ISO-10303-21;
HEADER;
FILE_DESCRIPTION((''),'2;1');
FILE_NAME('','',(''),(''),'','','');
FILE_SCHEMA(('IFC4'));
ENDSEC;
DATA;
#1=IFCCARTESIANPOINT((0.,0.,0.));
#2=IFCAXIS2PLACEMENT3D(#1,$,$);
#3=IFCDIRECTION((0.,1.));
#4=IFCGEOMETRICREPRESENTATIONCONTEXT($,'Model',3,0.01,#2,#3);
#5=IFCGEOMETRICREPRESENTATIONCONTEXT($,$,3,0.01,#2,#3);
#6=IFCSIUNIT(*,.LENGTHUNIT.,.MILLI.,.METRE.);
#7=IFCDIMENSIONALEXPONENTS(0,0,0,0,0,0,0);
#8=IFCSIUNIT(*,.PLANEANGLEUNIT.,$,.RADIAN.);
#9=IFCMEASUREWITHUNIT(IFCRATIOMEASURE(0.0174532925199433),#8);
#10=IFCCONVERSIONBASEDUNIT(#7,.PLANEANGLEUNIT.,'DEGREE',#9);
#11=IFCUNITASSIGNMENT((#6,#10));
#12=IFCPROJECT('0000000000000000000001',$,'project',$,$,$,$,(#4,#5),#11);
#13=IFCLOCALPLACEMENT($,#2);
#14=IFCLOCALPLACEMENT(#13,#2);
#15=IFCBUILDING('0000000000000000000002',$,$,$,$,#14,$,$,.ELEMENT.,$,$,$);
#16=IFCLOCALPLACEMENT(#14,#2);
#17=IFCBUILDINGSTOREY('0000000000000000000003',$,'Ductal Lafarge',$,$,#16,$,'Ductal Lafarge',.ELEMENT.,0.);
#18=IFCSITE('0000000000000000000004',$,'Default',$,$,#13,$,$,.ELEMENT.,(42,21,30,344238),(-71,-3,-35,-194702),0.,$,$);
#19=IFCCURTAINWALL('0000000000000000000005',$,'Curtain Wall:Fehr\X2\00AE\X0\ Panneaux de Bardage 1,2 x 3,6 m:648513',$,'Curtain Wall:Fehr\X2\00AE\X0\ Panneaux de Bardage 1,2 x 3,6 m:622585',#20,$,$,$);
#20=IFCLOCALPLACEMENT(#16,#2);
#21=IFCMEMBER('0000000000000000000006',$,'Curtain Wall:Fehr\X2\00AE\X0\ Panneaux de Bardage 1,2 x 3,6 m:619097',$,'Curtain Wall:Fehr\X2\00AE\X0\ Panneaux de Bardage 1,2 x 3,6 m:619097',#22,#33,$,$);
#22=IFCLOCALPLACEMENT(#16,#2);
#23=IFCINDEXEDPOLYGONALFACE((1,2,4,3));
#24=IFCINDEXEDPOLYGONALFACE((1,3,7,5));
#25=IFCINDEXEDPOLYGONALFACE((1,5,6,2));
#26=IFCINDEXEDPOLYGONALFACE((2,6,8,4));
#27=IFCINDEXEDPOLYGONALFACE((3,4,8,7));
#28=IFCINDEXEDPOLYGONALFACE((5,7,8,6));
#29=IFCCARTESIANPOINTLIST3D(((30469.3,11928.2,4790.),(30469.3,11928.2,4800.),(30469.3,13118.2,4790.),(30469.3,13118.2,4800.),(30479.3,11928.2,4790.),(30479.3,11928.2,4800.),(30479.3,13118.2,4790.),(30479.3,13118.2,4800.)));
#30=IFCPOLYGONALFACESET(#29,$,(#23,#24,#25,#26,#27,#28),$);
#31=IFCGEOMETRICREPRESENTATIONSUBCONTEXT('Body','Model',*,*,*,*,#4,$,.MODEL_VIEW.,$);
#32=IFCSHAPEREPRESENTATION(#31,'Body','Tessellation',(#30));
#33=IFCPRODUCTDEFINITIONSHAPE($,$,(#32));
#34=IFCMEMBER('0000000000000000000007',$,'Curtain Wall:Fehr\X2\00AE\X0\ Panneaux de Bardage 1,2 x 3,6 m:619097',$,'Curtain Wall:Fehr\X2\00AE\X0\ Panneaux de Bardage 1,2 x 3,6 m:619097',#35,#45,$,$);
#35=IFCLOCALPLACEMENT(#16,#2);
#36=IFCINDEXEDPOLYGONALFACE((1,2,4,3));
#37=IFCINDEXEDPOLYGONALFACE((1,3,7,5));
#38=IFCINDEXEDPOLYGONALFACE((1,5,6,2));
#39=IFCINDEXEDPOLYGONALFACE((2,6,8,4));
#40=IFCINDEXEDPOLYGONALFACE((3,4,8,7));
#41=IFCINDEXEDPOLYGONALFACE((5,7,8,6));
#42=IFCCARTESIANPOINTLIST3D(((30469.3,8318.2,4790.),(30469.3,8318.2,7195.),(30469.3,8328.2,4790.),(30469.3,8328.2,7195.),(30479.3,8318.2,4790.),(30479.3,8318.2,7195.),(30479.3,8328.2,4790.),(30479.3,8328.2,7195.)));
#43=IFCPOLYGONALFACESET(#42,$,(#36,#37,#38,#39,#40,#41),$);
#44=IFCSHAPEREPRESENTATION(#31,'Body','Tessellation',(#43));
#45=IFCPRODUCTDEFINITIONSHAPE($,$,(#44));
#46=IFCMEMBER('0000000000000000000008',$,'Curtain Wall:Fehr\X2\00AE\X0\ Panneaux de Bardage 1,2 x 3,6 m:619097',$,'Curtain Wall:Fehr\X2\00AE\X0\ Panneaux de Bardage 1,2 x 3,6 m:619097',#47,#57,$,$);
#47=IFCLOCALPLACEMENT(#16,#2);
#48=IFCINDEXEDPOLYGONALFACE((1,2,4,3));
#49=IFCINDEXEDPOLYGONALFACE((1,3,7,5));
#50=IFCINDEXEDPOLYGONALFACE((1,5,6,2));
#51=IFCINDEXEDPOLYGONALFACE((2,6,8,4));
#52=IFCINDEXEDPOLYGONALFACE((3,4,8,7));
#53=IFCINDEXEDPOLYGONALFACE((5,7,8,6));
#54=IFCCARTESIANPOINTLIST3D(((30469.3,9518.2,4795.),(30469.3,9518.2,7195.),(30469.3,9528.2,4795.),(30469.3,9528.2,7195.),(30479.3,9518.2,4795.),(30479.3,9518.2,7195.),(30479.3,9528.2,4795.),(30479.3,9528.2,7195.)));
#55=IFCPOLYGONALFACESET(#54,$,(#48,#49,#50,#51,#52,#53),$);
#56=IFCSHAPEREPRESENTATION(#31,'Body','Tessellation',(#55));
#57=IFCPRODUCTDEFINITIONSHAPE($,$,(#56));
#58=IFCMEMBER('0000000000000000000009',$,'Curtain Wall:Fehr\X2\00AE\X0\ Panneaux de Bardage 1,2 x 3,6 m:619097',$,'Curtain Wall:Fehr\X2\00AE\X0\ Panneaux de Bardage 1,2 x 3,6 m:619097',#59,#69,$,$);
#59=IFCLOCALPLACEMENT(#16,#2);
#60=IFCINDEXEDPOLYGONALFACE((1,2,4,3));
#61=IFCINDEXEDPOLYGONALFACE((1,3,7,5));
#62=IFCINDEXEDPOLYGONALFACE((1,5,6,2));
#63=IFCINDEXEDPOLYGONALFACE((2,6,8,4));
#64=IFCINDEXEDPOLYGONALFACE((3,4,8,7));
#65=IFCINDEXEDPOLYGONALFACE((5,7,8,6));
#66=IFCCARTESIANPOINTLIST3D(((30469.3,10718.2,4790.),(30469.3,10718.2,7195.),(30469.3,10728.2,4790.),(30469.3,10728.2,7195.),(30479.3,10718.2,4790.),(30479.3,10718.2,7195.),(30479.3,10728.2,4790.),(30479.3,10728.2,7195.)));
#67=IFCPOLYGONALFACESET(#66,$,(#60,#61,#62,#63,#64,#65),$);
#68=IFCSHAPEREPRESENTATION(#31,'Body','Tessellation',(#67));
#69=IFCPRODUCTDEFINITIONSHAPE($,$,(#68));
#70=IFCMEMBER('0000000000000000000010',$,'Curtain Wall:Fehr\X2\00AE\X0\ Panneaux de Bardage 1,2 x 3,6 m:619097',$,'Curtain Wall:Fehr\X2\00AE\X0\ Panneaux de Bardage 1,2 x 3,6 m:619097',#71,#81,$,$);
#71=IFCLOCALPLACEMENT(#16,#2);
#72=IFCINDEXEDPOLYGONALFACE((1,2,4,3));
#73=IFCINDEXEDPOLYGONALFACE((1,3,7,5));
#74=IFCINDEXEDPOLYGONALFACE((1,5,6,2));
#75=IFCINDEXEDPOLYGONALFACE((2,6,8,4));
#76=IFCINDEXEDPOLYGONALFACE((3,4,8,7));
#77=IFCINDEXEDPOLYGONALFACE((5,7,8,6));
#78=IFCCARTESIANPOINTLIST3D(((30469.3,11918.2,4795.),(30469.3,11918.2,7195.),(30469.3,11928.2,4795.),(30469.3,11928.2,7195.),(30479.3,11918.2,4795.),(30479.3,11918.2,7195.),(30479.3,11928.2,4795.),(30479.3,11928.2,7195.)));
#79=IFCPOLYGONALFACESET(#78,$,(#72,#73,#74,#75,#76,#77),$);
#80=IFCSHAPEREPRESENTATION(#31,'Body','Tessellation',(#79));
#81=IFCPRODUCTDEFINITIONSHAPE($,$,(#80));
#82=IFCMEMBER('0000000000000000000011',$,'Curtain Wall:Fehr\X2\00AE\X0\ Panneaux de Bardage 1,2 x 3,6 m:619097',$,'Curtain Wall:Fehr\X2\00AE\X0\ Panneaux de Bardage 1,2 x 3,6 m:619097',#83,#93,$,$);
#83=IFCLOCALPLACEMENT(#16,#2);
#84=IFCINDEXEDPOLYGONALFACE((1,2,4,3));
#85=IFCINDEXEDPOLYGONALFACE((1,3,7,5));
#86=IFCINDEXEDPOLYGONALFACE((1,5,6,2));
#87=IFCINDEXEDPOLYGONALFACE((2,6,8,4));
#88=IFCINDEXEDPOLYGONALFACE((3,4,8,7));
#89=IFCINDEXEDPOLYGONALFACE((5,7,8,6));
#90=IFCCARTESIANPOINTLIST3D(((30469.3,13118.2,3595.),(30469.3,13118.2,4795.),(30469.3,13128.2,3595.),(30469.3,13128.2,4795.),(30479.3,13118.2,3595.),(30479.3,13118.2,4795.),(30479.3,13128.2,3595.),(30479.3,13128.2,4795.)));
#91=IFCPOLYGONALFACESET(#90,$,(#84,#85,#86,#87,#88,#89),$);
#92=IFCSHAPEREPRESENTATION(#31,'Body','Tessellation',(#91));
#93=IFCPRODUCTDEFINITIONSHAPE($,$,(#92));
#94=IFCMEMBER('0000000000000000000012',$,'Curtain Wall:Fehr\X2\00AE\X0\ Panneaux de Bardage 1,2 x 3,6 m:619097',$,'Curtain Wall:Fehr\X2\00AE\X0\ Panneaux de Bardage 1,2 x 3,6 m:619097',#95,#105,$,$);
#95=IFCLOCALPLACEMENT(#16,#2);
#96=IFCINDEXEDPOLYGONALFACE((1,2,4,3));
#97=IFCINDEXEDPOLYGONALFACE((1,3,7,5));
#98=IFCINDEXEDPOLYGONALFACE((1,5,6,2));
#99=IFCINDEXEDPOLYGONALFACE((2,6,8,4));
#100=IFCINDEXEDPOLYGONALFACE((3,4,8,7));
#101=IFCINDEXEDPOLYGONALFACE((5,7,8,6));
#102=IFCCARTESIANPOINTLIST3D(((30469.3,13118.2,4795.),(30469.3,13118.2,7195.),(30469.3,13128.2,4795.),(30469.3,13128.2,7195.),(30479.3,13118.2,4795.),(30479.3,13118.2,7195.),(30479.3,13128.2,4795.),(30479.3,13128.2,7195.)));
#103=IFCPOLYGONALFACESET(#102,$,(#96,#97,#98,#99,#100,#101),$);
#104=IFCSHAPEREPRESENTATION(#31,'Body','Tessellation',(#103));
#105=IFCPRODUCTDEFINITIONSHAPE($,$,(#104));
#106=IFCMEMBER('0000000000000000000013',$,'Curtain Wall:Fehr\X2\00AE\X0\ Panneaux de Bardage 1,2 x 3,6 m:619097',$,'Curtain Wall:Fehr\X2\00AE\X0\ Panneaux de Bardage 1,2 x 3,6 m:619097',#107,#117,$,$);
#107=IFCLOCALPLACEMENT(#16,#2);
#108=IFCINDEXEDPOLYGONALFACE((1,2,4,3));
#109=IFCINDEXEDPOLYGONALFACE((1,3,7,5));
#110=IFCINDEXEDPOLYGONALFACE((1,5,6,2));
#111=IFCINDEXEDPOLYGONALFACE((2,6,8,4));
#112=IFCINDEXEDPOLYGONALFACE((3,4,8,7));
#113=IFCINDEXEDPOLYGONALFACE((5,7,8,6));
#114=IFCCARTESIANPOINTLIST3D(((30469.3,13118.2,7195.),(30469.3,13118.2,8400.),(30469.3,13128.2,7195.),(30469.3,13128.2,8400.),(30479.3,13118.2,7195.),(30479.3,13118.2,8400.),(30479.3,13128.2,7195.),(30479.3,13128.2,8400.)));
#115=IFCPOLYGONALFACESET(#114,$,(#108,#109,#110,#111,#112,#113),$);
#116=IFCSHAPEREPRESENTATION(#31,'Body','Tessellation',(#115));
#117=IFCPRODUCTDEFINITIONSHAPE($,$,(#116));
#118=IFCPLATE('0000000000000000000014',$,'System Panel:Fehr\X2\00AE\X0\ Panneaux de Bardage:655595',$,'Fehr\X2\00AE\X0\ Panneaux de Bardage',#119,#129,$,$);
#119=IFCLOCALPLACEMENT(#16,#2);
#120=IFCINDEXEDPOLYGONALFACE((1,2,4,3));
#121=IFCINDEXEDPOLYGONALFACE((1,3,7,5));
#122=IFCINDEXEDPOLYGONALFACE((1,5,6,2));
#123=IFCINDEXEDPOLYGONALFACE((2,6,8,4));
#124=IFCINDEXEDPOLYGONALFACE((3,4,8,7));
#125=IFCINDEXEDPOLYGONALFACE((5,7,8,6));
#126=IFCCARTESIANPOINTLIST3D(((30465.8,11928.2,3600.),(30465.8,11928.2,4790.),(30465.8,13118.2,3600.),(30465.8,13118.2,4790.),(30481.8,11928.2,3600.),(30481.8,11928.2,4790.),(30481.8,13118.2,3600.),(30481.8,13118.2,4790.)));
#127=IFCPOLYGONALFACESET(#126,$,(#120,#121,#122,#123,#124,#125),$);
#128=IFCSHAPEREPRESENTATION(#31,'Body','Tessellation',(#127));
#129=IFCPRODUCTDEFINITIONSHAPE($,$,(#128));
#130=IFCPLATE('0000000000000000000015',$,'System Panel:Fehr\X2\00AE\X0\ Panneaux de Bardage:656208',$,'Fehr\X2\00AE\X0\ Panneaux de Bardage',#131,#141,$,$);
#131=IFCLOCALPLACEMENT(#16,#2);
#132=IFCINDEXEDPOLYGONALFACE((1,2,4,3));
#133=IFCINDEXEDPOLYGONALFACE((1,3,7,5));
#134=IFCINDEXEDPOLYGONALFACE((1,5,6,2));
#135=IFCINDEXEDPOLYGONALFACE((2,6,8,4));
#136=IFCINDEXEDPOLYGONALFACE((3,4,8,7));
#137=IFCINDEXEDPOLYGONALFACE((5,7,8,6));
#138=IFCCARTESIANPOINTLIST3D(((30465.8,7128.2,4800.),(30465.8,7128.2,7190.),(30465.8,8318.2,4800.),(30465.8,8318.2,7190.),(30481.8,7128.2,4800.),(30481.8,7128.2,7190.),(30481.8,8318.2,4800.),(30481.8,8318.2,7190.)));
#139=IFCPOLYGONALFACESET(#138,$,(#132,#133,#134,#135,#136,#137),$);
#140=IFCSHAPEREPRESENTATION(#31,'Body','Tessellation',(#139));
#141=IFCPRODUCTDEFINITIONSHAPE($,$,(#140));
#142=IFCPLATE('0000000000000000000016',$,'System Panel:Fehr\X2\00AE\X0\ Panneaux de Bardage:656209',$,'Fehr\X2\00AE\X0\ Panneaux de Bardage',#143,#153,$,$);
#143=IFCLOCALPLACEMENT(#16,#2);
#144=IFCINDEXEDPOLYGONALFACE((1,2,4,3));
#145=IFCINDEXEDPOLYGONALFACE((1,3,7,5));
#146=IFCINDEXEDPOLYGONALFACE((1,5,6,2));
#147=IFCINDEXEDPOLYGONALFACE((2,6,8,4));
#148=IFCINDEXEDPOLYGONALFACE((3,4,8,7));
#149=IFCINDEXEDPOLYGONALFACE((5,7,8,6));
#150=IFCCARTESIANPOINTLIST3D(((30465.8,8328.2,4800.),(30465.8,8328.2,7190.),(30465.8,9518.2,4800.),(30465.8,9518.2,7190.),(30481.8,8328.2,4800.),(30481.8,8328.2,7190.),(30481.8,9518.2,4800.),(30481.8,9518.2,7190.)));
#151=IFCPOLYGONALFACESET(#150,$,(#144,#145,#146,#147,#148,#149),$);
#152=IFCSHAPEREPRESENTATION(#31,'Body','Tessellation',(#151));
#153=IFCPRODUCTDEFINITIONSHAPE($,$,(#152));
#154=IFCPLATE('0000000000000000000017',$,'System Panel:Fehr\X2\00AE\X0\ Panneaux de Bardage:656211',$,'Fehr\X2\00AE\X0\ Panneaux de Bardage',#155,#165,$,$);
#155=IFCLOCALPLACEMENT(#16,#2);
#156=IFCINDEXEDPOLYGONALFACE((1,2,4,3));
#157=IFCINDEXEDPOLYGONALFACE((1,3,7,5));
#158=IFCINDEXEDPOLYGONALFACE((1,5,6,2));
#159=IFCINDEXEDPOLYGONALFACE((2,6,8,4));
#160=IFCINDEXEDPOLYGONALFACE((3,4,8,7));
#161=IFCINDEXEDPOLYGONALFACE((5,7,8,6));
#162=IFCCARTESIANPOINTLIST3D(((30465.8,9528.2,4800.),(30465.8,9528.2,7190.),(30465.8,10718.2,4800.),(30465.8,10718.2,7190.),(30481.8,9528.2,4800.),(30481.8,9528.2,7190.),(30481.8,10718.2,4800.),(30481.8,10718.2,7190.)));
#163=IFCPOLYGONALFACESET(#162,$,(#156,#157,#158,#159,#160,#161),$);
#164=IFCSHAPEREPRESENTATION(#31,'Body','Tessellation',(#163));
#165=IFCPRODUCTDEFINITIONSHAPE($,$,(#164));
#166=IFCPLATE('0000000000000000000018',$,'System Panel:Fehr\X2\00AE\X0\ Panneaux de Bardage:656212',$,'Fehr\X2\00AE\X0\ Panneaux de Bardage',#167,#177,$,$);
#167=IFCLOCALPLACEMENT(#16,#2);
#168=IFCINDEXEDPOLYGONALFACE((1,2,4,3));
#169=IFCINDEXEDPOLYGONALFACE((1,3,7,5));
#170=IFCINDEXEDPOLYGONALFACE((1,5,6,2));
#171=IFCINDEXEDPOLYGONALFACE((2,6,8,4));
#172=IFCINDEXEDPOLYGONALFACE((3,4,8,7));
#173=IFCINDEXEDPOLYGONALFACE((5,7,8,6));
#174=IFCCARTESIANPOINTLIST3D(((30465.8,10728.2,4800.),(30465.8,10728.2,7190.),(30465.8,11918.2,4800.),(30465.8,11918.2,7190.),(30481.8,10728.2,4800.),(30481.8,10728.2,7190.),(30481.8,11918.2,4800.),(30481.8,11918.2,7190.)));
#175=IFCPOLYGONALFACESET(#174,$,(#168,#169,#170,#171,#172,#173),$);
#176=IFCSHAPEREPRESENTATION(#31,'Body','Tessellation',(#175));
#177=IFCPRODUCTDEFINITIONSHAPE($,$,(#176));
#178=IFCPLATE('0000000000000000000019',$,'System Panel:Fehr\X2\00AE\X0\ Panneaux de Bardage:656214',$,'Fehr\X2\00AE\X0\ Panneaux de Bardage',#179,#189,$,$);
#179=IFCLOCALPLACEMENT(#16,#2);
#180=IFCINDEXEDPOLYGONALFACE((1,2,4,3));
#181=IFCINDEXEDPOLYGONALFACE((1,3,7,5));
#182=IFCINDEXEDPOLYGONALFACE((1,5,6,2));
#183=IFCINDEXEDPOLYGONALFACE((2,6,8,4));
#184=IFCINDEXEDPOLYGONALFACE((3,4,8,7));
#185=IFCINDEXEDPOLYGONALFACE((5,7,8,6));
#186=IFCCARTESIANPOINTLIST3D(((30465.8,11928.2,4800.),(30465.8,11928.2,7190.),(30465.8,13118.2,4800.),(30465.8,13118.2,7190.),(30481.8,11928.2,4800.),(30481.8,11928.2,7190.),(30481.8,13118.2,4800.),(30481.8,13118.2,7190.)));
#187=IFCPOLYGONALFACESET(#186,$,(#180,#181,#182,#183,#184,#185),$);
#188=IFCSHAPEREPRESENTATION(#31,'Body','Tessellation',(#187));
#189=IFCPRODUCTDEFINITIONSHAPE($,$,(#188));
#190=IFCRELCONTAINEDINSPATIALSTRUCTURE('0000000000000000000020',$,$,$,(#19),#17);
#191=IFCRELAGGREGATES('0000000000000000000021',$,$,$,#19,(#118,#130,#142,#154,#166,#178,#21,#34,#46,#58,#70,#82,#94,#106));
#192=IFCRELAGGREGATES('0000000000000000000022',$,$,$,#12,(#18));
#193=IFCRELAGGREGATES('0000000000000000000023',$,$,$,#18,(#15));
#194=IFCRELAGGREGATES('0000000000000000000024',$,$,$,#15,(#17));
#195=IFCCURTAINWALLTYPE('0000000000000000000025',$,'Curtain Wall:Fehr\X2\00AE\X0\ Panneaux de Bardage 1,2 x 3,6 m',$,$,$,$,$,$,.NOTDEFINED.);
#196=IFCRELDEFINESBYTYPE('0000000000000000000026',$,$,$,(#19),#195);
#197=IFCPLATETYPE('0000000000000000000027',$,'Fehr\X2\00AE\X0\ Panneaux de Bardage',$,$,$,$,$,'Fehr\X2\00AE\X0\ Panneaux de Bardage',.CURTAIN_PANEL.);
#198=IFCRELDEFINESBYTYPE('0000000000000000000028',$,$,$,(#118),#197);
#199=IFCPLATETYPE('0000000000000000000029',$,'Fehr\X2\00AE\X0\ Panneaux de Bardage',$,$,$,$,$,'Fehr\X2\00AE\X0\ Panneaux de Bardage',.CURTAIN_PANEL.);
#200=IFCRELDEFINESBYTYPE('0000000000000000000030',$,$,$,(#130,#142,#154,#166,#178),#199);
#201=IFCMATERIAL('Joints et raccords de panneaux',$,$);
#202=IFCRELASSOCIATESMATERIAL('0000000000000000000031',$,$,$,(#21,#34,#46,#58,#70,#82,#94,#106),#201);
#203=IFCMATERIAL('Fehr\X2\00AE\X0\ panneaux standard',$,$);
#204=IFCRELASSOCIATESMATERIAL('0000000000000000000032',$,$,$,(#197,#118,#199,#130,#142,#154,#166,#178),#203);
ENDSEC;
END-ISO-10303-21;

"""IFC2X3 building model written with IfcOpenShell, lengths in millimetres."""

from ifc_helpers import new_model, entity, si_unit, converted_unit, direction, frame, frame_2d, origin, origin_2d_with_axis, place, context, subcontext, project, spatial, rectangle, extrude, source, transform, mapped, material, type_object, type_shapes, element, aggregate, save


model = new_model("IFC2X3")

# Units and contexts
model_context = context("Model", 3, precision=0.01, world=origin(), true_north=direction((0.0, 1.0)))
context_of_model = context(None, 3, precision=0.01, world=origin(), true_north=direction((0.0, 1.0)))
body_context = subcontext(model_context, "Body", "Model", "MODEL_VIEW")
ifc_project = project(units=[si_unit("LENGTHUNIT", "METRE", prefix="MILLI"), converted_unit("PLANEANGLEUNIT", "DEGREE", entity("IfcRatioMeasure", 0.0174532925199433), si_unit("PLANEANGLEUNIT", "RADIAN"), dimensions=[0, 0, 0, 0, 0, 0, 0])], contexts=[model_context, context_of_model])

# Site, building, storey
site_placement = place(None, origin())
site = spatial("IfcSite", under=ifc_project, at=site_placement, Name="Default", CompositionType="ELEMENT", RefLatitude=(42, 21, 30, 344238), RefLongitude=(-71, -3, -35, -194702), RefElevation=0.0)
building_placement = place(site_placement, origin())
building = spatial("IfcBuilding", under=site, at=building_placement, CompositionType="ELEMENT")
storey_placement = place(building_placement, origin())
storey = spatial("IfcBuildingStorey", under=building, at=storey_placement, Name="Ductal Lafarge", LongName="Ductal Lafarge", CompositionType="ELEMENT", Elevation=0.0)

# Curtain wall, members, plates
curtain_wall_type = type_object("IfcCurtainWallType", Name="Curtain Wall:Fehr® Panneaux de Bardage 1,2 x 3,6 m", PredefinedType="NOTDEFINED")
curtain_wall_placement = place(storey_placement, origin())
curtain_wall = element("IfcCurtainWall", 1, at=curtain_wall_placement, inside=storey, type_object=curtain_wall_type, Name="Curtain Wall:Fehr® Panneaux de Bardage 1,2 x 3,6 m:648513", ObjectType="Curtain Wall:Fehr® Panneaux de Bardage 1,2 x 3,6 m:622585")
ifc_material_1 = material(Name="Joints et raccords de panneaux")
member_1_placement = place(curtain_wall_placement, frame((30469.3, 11928.2, 4790.0)))
member_1 = element("IfcMember", 2, at=member_1_placement, material=ifc_material_1, Name="Curtain Wall:Fehr® Panneaux de Bardage 1,2 x 3,6 m:619097", ObjectType="Curtain Wall:Fehr® Panneaux de Bardage 1,2 x 3,6 m:619097", context=body_context, shape_type="SweptSolid", body=[
    extrude(rectangle(XDim=1190.0, YDim=10.0, at=frame_2d((0.0, 0.0), x_axis=(1.0, 0.0))), frame((5.0, 595.0, 0.0), z_axis=(0.0, 0.0, 1.0), x_axis=(0.0, -1.0, 0.0)), (0.0, 0.0, 1.0), 10.0),
])
member_2_placement = place(curtain_wall_placement, frame((30469.3, 8318.2, 4790.0)))
member_2 = element("IfcMember", 3, at=member_2_placement, material=ifc_material_1, Name="Curtain Wall:Fehr® Panneaux de Bardage 1,2 x 3,6 m:619097", ObjectType="Curtain Wall:Fehr® Panneaux de Bardage 1,2 x 3,6 m:619097", context=body_context, shape_type="SweptSolid", body=[
    extrude(rectangle(XDim=10.0, YDim=10.0, at=frame_2d((0.0, 0.0), x_axis=(1.0, 0.0))), frame((5.0, 5.0, 0.0), z_axis=(0.0, 0.0, 1.0), x_axis=(-1.0, 0.0, 0.0)), (0.0, 0.0, 1.0), 2405.0),
])
member_3_placement = place(curtain_wall_placement, frame((30469.3, 9518.2, 4795.0)))
member_3 = element("IfcMember", 4, at=member_3_placement, material=ifc_material_1, Name="Curtain Wall:Fehr® Panneaux de Bardage 1,2 x 3,6 m:619097", ObjectType="Curtain Wall:Fehr® Panneaux de Bardage 1,2 x 3,6 m:619097", context=body_context, shape_type="SweptSolid", body=[
    extrude(rectangle(XDim=10.0, YDim=10.0, at=frame_2d((0.0, 0.0), x_axis=(1.0, 0.0))), frame((5.0, 5.0, 0.0), z_axis=(0.0, 0.0, 1.0), x_axis=(-1.0, 0.0, 0.0)), (0.0, 0.0, 1.0), 2400.0),
])
member_4_placement = place(curtain_wall_placement, frame((30469.3, 10718.2, 4790.0)))
member_4 = element("IfcMember", 5, at=member_4_placement, material=ifc_material_1, Name="Curtain Wall:Fehr® Panneaux de Bardage 1,2 x 3,6 m:619097", ObjectType="Curtain Wall:Fehr® Panneaux de Bardage 1,2 x 3,6 m:619097", context=body_context, shape_type="SweptSolid", body=[
    extrude(rectangle(XDim=10.0, YDim=10.0, at=frame_2d((0.0, 0.0), x_axis=(1.0, 0.0))), frame((5.0, 5.0, 0.0), z_axis=(0.0, 0.0, 1.0), x_axis=(-1.0, 0.0, 0.0)), (0.0, 0.0, 1.0), 2405.0),
])
member_5_placement = place(curtain_wall_placement, frame((30469.3, 11918.2, 4795.0)))
member_5 = element("IfcMember", 6, at=member_5_placement, material=ifc_material_1, Name="Curtain Wall:Fehr® Panneaux de Bardage 1,2 x 3,6 m:619097", ObjectType="Curtain Wall:Fehr® Panneaux de Bardage 1,2 x 3,6 m:619097", context=body_context, shape_type="SweptSolid", body=[
    extrude(rectangle(XDim=10.0, YDim=10.0, at=frame_2d((0.0, 0.0), x_axis=(1.0, 0.0))), frame((5.0, 5.0, 0.0), z_axis=(0.0, 0.0, 1.0), x_axis=(-1.0, 0.0, 0.0)), (0.0, 0.0, 1.0), 2400.0),
])
member_6_placement = place(curtain_wall_placement, frame((30469.3, 13118.2, 3595.0)))
member_6 = element("IfcMember", 7, at=member_6_placement, material=ifc_material_1, Name="Curtain Wall:Fehr® Panneaux de Bardage 1,2 x 3,6 m:619097", ObjectType="Curtain Wall:Fehr® Panneaux de Bardage 1,2 x 3,6 m:619097", context=body_context, shape_type="SweptSolid", body=[
    extrude(rectangle(XDim=10.0, YDim=10.0, at=frame_2d((0.0, 0.0), x_axis=(1.0, 0.0))), frame((5.0, 5.0, 0.0), z_axis=(0.0, 0.0, 1.0), x_axis=(-1.0, 0.0, 0.0)), (0.0, 0.0, 1.0), 1200.0),
])
member_7_placement = place(curtain_wall_placement, frame((30469.3, 13118.2, 4795.0)))
member_7 = element("IfcMember", 8, at=member_7_placement, material=ifc_material_1, Name="Curtain Wall:Fehr® Panneaux de Bardage 1,2 x 3,6 m:619097", ObjectType="Curtain Wall:Fehr® Panneaux de Bardage 1,2 x 3,6 m:619097", context=body_context, shape_type="SweptSolid", body=[
    extrude(rectangle(XDim=10.0, YDim=10.0, at=frame_2d((0.0, 0.0), x_axis=(1.0, 0.0))), frame((5.0, 5.0, 0.0), z_axis=(0.0, 0.0, 1.0), x_axis=(-1.0, 0.0, 0.0)), (0.0, 0.0, 1.0), 2400.0),
])
member_8_placement = place(curtain_wall_placement, frame((30469.3, 13118.2, 7195.0)))
member_8 = element("IfcMember", 9, at=member_8_placement, material=ifc_material_1, Name="Curtain Wall:Fehr® Panneaux de Bardage 1,2 x 3,6 m:619097", ObjectType="Curtain Wall:Fehr® Panneaux de Bardage 1,2 x 3,6 m:619097", context=body_context, shape_type="SweptSolid", body=[
    extrude(rectangle(XDim=10.0, YDim=10.0, at=frame_2d((0.0, 0.0), x_axis=(1.0, 0.0))), frame((5.0, 5.0, 0.0), z_axis=(0.0, 0.0, 1.0), x_axis=(-1.0, 0.0, 0.0)), (0.0, 0.0, 1.0), 1205.0),
])
ifc_material_2 = material(Name="Fehr® panneaux standard")
plate_type_1 = type_object("IfcPlateType", Name="Fehr® Panneaux de Bardage", ElementType="Fehr® Panneaux de Bardage", PredefinedType="CURTAIN_PANEL", material=ifc_material_2)
shared_shape_1 = source(origin(), body_context, "Body", "SweptSolid", [
    extrude(rectangle(XDim=16.0, YDim=1190.0, at=origin_2d_with_axis()), frame((0.0, 0.0, 0.0), z_axis=(0.0, 0.0, 1.0), x_axis=(0.0, 1.0, 0.0)), (0.0, 0.0, 1.0), 1190.0),
])
type_shapes(plate_type_1, [shared_shape_1])
plate_1_placement = place(curtain_wall_placement, frame((30473.8, 12523.2, 3600.0), z_axis=(0.0, 0.0, 1.0), x_axis=(0.0, 1.0, 0.0)))
plate_1 = element("IfcPlate", 10, at=plate_1_placement, type_object=plate_type_1, material=ifc_material_2, Name="System Panel:Fehr® Panneaux de Bardage:655595", ObjectType="Fehr® Panneaux de Bardage", context=body_context, shape_type="MappedRepresentation", body=[
    mapped(shared_shape_1, transform((0.0, 0.0, 0.0), scale=1.0)),
])
plate_type_2 = type_object("IfcPlateType", Name="Fehr® Panneaux de Bardage", ElementType="Fehr® Panneaux de Bardage", PredefinedType="CURTAIN_PANEL", material=ifc_material_2)
shared_shape_2 = source(origin(), body_context, "Body", "SweptSolid", [
    extrude(rectangle(XDim=16.0, YDim=1190.0, at=origin_2d_with_axis()), frame((0.0, 0.0, 0.0), z_axis=(0.0, 0.0, 1.0), x_axis=(0.0, 1.0, 0.0)), (0.0, 0.0, 1.0), 2390.0),
])
type_shapes(plate_type_2, [shared_shape_2])
plate_2_placement = place(curtain_wall_placement, frame((30473.8, 7723.2, 4800.0), z_axis=(0.0, 0.0, 1.0), x_axis=(0.0, 1.0, 0.0)))
plate_2 = element("IfcPlate", 11, at=plate_2_placement, type_object=plate_type_2, material=ifc_material_2, Name="System Panel:Fehr® Panneaux de Bardage:656208", ObjectType="Fehr® Panneaux de Bardage", context=body_context, shape_type="MappedRepresentation", body=[
    mapped(shared_shape_2, transform((0.0, 0.0, 0.0), scale=1.0)),
])
plate_3_placement = place(curtain_wall_placement, frame((30473.8, 8923.2, 4800.0), z_axis=(0.0, 0.0, 1.0), x_axis=(0.0, 1.0, 0.0)))
plate_3 = element("IfcPlate", 12, at=plate_3_placement, type_object=plate_type_2, material=ifc_material_2, Name="System Panel:Fehr® Panneaux de Bardage:656209", ObjectType="Fehr® Panneaux de Bardage", context=body_context, shape_type="MappedRepresentation", body=[
    mapped(shared_shape_2, transform((0.0, 0.0, 0.0), scale=1.0)),
])
plate_4_placement = place(curtain_wall_placement, frame((30473.8, 10123.2, 4800.0), z_axis=(0.0, 0.0, 1.0), x_axis=(0.0, 1.0, 0.0)))
plate_4 = element("IfcPlate", 13, at=plate_4_placement, type_object=plate_type_2, material=ifc_material_2, Name="System Panel:Fehr® Panneaux de Bardage:656211", ObjectType="Fehr® Panneaux de Bardage", context=body_context, shape_type="MappedRepresentation", body=[
    mapped(shared_shape_2, transform((0.0, 0.0, 0.0), scale=1.0)),
])
plate_5_placement = place(curtain_wall_placement, frame((30473.8, 11323.2, 4800.0), z_axis=(0.0, 0.0, 1.0), x_axis=(0.0, 1.0, 0.0)))
plate_5 = element("IfcPlate", 14, at=plate_5_placement, type_object=plate_type_2, material=ifc_material_2, Name="System Panel:Fehr® Panneaux de Bardage:656212", ObjectType="Fehr® Panneaux de Bardage", context=body_context, shape_type="MappedRepresentation", body=[
    mapped(shared_shape_2, transform((0.0, 0.0, 0.0), scale=1.0)),
])
plate_6_placement = place(curtain_wall_placement, frame((30473.8, 12523.2, 4800.0), z_axis=(0.0, 0.0, 1.0), x_axis=(0.0, 1.0, 0.0)))
plate_6 = element("IfcPlate", 15, at=plate_6_placement, type_object=plate_type_2, material=ifc_material_2, Name="System Panel:Fehr® Panneaux de Bardage:656214", ObjectType="Fehr® Panneaux de Bardage", context=body_context, shape_type="MappedRepresentation", body=[
    mapped(shared_shape_2, transform((0.0, 0.0, 0.0), scale=1.0)),
])
aggregate(curtain_wall, [plate_1, plate_2, plate_3, plate_4, plate_5, plate_6, member_1, member_2, member_3, member_4, member_5, member_6, member_7, member_8])

save(model, "model.ifc")
